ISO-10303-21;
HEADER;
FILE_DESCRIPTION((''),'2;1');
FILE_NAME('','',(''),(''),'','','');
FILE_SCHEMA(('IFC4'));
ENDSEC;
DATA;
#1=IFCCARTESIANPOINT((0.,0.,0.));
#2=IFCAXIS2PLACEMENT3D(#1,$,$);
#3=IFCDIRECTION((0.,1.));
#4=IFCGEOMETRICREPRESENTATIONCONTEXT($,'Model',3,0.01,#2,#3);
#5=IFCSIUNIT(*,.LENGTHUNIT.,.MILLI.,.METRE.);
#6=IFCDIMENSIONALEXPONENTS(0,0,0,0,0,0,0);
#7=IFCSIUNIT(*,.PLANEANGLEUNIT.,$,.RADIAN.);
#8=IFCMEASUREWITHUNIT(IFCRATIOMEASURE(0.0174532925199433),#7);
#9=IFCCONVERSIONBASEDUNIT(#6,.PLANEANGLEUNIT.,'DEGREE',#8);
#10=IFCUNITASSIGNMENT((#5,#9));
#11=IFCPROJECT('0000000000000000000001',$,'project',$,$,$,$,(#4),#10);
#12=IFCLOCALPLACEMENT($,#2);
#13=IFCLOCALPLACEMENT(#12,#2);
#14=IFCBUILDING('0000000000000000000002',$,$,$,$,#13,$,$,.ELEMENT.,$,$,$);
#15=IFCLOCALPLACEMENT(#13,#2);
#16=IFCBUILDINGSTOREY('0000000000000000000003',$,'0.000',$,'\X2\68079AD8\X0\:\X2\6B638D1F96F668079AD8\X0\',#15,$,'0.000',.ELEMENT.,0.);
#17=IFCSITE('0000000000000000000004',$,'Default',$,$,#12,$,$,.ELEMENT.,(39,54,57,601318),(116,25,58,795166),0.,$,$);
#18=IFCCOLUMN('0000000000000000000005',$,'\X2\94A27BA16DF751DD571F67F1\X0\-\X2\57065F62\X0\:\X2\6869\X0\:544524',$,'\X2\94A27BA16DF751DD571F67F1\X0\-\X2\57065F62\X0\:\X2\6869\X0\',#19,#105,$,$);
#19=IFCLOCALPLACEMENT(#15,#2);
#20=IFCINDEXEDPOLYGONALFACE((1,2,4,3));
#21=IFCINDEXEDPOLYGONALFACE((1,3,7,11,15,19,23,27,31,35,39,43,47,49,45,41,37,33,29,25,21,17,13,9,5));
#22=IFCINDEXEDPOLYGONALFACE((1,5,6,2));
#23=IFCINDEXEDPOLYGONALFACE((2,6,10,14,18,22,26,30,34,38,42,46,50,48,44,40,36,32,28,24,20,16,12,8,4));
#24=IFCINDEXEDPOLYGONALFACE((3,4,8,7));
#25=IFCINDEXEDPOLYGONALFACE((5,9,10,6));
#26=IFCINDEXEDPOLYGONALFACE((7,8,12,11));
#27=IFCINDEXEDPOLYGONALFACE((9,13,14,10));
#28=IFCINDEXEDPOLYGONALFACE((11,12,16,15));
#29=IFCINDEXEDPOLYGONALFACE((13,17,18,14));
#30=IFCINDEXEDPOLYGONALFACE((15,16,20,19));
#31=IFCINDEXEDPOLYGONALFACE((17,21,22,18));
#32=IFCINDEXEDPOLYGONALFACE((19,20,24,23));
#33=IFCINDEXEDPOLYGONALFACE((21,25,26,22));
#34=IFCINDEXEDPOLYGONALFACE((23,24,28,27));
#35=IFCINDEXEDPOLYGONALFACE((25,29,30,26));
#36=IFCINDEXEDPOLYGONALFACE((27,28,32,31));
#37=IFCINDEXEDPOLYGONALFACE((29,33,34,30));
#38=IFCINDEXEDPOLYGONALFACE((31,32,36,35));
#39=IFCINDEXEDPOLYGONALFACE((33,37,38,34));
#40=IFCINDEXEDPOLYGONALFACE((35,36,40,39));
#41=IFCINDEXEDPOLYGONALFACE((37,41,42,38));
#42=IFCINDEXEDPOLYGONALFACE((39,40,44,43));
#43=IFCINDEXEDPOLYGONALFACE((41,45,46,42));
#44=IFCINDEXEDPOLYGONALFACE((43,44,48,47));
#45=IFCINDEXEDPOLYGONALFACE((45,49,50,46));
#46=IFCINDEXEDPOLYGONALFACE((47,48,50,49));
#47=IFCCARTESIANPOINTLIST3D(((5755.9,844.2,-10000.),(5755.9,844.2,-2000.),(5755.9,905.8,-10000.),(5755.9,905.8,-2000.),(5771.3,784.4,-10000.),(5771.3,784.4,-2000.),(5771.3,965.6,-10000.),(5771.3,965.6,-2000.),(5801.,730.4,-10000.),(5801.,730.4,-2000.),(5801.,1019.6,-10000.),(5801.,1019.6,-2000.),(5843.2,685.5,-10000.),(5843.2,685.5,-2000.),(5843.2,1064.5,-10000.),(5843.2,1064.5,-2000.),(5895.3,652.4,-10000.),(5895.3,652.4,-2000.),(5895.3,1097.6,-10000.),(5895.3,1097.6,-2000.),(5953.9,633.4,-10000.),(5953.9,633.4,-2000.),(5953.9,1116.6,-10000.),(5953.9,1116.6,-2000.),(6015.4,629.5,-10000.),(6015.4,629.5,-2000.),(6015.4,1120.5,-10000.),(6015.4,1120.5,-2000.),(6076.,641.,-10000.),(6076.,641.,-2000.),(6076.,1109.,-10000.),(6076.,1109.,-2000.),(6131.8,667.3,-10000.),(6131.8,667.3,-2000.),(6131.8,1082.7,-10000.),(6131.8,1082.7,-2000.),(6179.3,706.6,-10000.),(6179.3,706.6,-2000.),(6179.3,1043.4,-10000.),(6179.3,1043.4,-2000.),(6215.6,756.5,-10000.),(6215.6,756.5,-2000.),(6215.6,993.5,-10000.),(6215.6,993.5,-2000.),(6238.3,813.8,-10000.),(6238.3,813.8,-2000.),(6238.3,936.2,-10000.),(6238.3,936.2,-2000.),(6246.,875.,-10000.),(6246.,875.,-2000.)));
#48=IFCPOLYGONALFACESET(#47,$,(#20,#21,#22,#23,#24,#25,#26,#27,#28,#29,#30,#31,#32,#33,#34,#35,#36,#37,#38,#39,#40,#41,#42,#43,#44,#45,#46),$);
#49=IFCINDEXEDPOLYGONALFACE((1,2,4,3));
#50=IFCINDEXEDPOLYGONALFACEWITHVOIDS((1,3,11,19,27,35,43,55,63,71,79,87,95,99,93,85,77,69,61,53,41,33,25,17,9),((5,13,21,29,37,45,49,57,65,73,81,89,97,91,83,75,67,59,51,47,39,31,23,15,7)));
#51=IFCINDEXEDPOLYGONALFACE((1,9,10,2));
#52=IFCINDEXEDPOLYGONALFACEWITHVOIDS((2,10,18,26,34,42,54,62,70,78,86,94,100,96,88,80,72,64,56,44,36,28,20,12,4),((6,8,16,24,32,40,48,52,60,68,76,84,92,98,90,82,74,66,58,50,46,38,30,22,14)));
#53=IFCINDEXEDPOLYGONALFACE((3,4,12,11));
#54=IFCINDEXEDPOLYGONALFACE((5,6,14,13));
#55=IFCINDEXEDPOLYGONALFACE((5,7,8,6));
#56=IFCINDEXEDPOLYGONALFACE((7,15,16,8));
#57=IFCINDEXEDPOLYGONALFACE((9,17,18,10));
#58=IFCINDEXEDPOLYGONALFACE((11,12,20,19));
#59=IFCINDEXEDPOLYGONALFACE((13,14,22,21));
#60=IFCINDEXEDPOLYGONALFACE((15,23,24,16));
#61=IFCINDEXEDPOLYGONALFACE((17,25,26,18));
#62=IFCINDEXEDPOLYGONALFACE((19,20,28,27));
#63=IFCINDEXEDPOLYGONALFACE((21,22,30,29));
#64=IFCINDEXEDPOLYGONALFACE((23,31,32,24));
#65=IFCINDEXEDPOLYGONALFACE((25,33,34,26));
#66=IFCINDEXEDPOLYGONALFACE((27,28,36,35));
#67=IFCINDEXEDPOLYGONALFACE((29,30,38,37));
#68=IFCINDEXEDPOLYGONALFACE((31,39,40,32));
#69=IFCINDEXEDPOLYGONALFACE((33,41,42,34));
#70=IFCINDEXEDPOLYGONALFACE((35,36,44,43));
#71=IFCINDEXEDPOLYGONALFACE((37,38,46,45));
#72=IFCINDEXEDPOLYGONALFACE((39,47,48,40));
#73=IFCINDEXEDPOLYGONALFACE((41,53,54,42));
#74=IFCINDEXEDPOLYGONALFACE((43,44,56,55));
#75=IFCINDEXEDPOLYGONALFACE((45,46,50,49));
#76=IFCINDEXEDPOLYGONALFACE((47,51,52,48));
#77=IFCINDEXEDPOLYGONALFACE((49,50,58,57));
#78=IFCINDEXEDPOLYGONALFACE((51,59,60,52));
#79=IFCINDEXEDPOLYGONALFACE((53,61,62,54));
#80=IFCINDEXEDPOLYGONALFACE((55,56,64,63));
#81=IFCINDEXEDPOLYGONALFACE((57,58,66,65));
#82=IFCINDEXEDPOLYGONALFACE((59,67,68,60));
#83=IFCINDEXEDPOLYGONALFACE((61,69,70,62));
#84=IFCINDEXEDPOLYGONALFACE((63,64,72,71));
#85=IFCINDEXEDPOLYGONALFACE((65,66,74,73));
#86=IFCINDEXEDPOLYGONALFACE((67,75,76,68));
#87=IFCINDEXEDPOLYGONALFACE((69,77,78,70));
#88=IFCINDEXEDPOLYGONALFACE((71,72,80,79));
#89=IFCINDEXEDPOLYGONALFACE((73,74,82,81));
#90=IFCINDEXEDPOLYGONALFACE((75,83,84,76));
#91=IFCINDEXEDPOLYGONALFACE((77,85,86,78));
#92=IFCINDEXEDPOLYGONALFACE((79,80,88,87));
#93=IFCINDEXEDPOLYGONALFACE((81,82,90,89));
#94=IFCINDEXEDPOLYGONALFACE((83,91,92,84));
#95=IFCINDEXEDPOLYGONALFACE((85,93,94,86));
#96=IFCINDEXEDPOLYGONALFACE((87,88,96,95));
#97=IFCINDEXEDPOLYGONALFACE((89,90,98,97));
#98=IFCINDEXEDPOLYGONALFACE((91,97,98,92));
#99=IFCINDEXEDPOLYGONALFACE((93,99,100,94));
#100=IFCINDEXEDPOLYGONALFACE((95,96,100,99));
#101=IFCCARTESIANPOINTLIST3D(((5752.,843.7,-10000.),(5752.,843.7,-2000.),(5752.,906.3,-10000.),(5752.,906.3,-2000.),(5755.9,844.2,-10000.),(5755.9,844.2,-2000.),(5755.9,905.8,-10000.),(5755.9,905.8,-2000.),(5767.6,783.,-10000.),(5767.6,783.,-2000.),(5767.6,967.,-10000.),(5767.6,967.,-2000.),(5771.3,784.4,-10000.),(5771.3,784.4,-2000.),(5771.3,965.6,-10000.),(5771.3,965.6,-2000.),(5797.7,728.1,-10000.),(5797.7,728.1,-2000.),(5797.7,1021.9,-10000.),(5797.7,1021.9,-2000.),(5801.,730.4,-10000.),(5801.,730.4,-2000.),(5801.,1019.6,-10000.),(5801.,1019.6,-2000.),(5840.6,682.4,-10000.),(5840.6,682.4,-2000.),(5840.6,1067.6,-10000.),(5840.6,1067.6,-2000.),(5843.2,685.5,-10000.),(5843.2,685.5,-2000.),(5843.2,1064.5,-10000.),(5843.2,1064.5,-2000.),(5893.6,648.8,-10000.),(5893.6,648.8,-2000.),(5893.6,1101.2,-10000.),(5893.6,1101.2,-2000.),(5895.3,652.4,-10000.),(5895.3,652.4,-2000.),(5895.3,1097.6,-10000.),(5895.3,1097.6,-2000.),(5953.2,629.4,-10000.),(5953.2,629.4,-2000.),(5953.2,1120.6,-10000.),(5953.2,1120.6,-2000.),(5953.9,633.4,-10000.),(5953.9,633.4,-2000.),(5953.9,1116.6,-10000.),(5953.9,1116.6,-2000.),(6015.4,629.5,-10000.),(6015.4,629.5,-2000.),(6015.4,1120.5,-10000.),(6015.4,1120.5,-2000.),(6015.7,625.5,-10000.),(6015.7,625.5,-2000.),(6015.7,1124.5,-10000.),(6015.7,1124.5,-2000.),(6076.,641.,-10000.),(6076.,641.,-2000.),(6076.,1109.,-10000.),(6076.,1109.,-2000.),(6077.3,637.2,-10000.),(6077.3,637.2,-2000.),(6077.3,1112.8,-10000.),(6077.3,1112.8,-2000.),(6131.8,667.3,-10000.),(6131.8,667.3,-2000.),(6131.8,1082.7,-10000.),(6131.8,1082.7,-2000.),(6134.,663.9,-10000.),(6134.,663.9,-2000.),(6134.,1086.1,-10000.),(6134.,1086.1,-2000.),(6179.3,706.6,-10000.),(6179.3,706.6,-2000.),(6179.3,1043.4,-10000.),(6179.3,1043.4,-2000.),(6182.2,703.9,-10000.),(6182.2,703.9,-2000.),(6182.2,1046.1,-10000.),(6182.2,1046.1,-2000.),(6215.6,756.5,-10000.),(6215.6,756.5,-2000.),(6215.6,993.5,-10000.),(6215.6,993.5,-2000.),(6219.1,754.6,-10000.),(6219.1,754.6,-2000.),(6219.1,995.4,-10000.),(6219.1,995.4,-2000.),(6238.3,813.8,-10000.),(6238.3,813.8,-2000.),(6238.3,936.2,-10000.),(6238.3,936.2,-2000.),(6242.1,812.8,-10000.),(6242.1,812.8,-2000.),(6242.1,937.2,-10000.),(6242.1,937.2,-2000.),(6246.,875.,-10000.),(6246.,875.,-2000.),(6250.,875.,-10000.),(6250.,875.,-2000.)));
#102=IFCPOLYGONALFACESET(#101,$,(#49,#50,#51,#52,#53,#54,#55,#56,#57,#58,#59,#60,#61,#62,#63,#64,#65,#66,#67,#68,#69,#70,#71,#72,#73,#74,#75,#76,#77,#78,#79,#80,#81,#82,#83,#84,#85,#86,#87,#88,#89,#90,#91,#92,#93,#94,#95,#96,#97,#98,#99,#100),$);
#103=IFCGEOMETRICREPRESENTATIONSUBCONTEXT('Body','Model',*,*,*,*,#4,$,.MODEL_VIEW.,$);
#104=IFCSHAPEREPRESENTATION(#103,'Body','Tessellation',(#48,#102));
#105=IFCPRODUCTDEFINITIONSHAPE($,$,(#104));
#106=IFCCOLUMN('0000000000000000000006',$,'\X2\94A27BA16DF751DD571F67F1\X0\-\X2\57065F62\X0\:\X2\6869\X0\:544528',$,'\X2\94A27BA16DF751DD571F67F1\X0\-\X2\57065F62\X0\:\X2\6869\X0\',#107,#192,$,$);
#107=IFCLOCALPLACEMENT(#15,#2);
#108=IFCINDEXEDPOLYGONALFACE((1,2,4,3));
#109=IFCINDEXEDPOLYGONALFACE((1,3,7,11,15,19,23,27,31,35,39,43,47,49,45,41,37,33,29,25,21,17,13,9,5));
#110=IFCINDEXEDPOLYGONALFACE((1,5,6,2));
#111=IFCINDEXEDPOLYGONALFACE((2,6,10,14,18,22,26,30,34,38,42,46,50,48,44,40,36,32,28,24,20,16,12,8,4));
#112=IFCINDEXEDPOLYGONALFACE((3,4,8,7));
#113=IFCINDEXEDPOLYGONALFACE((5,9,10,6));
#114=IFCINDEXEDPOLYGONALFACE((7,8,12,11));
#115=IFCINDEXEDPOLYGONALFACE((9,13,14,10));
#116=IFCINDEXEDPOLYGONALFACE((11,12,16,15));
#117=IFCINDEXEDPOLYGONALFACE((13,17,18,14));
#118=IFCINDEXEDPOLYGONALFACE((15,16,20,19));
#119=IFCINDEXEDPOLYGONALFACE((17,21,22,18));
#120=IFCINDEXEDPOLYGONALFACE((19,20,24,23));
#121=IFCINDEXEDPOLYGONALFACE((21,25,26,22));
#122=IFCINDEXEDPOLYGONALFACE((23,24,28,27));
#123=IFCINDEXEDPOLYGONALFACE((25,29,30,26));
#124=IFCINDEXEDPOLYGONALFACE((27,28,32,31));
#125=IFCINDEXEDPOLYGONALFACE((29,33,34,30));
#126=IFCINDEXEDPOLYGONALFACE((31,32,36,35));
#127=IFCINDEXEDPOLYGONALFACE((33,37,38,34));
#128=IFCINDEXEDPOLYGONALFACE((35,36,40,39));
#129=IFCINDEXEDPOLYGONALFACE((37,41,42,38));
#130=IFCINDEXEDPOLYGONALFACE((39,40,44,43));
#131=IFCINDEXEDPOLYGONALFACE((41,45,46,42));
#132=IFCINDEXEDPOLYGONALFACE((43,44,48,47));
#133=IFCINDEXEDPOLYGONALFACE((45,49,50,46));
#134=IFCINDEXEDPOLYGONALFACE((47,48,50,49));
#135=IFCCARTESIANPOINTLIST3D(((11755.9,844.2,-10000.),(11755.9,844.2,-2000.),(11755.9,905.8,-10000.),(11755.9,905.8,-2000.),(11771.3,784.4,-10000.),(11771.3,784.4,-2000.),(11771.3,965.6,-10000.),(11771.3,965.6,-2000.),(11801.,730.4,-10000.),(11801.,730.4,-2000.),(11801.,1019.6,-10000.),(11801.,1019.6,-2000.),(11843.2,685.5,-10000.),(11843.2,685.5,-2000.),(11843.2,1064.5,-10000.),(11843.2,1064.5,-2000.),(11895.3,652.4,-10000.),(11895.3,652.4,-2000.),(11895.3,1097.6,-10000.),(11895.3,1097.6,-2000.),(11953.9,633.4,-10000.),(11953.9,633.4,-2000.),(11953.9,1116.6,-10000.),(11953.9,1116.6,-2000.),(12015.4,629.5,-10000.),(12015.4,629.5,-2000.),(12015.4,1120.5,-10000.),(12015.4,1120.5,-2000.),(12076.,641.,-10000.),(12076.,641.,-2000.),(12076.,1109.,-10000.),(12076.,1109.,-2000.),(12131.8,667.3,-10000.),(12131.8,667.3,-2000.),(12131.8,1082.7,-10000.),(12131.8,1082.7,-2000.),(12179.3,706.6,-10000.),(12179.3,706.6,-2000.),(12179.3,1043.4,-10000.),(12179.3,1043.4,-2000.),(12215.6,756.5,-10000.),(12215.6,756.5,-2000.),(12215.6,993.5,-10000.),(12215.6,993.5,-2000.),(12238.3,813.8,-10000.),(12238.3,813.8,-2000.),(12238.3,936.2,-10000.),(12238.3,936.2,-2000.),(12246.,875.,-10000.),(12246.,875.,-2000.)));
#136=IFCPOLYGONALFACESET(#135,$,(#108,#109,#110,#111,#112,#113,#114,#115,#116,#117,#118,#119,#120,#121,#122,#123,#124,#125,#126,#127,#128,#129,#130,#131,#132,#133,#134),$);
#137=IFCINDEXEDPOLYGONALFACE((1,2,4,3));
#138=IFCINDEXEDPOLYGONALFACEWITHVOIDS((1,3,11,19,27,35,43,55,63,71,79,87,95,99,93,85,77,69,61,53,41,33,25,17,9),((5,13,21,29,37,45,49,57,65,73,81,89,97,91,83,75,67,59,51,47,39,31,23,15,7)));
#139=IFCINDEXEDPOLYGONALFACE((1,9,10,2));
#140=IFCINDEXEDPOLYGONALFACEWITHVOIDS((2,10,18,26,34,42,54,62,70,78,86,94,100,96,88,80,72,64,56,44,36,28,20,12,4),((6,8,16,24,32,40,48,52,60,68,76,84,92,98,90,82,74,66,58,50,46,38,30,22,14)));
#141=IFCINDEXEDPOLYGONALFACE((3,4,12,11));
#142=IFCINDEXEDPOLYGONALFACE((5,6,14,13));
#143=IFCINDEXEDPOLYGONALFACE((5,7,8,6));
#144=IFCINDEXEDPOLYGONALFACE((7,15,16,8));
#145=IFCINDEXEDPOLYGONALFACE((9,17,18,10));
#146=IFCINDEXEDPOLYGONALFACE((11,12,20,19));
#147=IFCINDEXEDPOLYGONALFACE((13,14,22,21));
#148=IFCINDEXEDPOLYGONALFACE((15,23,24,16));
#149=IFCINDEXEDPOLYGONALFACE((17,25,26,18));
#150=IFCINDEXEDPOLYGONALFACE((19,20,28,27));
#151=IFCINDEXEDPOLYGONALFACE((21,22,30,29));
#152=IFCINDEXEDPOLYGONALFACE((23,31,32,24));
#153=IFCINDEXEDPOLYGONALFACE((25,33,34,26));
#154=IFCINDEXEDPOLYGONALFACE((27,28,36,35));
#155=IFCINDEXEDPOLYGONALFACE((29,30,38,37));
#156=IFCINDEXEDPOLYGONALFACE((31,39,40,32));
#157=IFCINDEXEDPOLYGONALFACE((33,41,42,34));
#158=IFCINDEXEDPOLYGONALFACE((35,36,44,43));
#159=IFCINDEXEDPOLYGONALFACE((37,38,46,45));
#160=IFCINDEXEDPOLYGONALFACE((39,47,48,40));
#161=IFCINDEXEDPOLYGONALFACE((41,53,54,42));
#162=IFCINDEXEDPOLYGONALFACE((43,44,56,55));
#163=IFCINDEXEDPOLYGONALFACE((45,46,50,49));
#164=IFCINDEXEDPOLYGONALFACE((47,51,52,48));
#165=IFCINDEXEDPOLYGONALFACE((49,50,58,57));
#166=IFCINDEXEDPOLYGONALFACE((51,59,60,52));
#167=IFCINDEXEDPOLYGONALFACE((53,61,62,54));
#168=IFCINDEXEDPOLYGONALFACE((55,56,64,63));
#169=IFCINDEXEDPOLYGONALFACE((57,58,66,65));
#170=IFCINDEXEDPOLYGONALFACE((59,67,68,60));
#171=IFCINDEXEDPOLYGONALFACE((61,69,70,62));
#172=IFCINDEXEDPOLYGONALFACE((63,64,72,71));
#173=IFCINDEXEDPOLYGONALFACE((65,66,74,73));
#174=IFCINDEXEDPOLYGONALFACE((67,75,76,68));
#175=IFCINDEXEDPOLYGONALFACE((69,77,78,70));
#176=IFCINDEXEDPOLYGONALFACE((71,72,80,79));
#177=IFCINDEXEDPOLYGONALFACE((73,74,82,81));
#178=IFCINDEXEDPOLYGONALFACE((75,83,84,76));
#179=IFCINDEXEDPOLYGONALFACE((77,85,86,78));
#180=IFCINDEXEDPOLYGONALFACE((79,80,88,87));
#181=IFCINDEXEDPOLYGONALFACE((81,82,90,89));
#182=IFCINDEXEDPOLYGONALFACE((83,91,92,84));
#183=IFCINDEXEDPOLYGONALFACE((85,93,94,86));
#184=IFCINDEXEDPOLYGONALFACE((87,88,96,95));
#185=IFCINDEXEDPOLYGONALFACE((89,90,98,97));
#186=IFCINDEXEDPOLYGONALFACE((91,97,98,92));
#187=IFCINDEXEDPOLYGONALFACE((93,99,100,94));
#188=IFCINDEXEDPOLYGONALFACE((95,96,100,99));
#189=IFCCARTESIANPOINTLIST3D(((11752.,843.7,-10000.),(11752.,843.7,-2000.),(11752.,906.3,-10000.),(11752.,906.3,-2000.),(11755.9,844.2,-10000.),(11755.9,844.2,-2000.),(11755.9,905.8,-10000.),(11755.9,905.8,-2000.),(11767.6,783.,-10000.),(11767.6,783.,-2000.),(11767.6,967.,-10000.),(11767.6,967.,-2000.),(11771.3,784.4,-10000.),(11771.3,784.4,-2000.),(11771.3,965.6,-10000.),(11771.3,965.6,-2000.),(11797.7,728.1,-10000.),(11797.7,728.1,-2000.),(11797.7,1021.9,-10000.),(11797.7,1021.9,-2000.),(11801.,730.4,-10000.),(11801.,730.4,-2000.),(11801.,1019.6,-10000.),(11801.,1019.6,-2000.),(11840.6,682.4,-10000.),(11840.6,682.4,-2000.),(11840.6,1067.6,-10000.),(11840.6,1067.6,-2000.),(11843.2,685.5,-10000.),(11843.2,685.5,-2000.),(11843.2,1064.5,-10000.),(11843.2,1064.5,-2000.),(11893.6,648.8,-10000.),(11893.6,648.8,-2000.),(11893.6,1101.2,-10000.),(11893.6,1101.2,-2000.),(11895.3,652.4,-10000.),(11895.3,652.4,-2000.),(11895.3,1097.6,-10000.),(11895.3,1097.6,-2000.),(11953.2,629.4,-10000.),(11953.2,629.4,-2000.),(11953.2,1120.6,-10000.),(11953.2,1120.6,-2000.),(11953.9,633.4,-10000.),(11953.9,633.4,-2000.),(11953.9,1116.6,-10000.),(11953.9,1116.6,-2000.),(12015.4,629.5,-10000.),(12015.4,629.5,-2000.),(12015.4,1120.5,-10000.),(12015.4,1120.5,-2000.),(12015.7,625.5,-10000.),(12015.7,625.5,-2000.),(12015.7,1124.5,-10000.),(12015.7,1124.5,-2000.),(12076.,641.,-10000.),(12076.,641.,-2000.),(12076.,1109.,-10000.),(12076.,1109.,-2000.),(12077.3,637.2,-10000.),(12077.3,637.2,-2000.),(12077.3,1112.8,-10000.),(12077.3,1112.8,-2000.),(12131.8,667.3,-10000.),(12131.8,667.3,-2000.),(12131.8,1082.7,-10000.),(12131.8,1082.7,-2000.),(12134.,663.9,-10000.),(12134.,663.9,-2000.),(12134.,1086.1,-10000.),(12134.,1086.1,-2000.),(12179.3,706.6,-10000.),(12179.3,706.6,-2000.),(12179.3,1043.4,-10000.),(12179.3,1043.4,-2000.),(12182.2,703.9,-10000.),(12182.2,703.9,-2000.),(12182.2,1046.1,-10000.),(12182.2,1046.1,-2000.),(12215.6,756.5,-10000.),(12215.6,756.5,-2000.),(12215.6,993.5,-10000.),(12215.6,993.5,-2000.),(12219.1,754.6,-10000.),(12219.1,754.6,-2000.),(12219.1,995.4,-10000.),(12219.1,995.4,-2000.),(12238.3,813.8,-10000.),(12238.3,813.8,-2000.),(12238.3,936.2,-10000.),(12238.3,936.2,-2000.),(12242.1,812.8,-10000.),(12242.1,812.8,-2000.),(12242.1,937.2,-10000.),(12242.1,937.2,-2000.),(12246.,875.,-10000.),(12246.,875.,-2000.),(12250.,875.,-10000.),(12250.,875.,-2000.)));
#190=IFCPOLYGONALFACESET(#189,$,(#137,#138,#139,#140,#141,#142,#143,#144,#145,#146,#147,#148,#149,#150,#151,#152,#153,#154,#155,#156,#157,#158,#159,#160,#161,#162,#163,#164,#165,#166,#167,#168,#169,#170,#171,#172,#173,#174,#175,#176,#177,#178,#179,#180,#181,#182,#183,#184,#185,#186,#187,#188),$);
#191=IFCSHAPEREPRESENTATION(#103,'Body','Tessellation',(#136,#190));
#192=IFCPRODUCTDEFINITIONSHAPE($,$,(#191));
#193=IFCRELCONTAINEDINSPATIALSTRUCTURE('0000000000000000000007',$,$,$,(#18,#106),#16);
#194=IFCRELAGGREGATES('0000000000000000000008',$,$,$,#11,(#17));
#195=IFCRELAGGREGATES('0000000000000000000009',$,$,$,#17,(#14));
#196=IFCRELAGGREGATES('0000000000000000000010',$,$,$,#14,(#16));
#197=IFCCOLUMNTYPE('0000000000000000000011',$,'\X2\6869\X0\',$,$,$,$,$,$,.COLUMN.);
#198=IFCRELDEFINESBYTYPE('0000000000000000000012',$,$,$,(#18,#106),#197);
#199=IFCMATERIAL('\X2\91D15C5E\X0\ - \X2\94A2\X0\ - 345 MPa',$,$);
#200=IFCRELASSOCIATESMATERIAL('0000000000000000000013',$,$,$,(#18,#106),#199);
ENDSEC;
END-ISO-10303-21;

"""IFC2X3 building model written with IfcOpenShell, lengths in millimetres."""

from ifc_helpers import new_model, entity, si_unit, converted_unit, direction, frame, frame_2d, origin, place, context, subcontext, project, spatial, circle, hollow_circle, extrude, source, transform, mapped, material, type_object, type_shapes, element, save


model = new_model("IFC2X3")

# Units and contexts
model_context = context("Model", 3, precision=0.01, world=origin(), true_north=direction((0.0, 1.0)))
body_context = subcontext(model_context, "Body", "Model", "MODEL_VIEW")
ifc_project = project(units=[si_unit("LENGTHUNIT", "METRE", prefix="MILLI"), converted_unit("PLANEANGLEUNIT", "DEGREE", entity("IfcRatioMeasure", 0.0174532925199433), si_unit("PLANEANGLEUNIT", "RADIAN"), dimensions=[0, 0, 0, 0, 0, 0, 0])], contexts=[model_context])

# Site, building, storey
site_placement = place(None, origin())
site = spatial("IfcSite", under=ifc_project, at=site_placement, Name="Default", CompositionType="ELEMENT", RefLatitude=(39, 54, 57, 601318), RefLongitude=(116, 25, 58, 795166), RefElevation=0.0)
building_placement = place(site_placement, origin())
building = spatial("IfcBuilding", under=site, at=building_placement, CompositionType="ELEMENT")
storey_placement = place(building_placement, origin())
storey = spatial("IfcBuildingStorey", under=building, at=storey_placement, Name="0.000", ObjectType="标高:正负零标高", LongName="0.000", CompositionType="ELEMENT", Elevation=0.0)

# Columns
ifc_material_1 = material(Name="金属 - 钢 - 345 MPa")
column_type = type_object("IfcColumnType", Name="桩", PredefinedType="COLUMN")
shared_shape = source(origin(), body_context, "Body", "SweptSolid", [
    extrude(circle(Radius=246.0, at=frame_2d((0.0, 0.0), x_axis=(1.0, 0.0))), frame((0.0, 0.0, -10000.0)), (0.0, 0.0, 1.0), 8000.0),
    extrude(hollow_circle(Radius=250.0, WallThickness=4.0, at=frame_2d((0.0, 0.0), x_axis=(1.0, 0.0))), frame((0.0, 0.0, -10000.0)), (0.0, 0.0, 1.0), 8000.0),
])
type_shapes(column_type, [shared_shape])
for number, where, name in (
    (1, (6000.0, 875.0, 0.0), "钢管混凝土柱-圆形:桩:544524"),
    (2, (12000.0, 875.0, 0.0), "钢管混凝土柱-圆形:桩:544528"),
):
    element("IfcColumn", number, at=place(storey_placement, frame(where)), inside=storey, type_object=column_type, material=ifc_material_1, Name=name, ObjectType="钢管混凝土柱-圆形:桩", context=body_context, shape_type="MappedRepresentation", body=[
        mapped(shared_shape, transform((0.0, 0.0, 0.0), scale=1.0)),
    ])

save(model, "model.ifc")
